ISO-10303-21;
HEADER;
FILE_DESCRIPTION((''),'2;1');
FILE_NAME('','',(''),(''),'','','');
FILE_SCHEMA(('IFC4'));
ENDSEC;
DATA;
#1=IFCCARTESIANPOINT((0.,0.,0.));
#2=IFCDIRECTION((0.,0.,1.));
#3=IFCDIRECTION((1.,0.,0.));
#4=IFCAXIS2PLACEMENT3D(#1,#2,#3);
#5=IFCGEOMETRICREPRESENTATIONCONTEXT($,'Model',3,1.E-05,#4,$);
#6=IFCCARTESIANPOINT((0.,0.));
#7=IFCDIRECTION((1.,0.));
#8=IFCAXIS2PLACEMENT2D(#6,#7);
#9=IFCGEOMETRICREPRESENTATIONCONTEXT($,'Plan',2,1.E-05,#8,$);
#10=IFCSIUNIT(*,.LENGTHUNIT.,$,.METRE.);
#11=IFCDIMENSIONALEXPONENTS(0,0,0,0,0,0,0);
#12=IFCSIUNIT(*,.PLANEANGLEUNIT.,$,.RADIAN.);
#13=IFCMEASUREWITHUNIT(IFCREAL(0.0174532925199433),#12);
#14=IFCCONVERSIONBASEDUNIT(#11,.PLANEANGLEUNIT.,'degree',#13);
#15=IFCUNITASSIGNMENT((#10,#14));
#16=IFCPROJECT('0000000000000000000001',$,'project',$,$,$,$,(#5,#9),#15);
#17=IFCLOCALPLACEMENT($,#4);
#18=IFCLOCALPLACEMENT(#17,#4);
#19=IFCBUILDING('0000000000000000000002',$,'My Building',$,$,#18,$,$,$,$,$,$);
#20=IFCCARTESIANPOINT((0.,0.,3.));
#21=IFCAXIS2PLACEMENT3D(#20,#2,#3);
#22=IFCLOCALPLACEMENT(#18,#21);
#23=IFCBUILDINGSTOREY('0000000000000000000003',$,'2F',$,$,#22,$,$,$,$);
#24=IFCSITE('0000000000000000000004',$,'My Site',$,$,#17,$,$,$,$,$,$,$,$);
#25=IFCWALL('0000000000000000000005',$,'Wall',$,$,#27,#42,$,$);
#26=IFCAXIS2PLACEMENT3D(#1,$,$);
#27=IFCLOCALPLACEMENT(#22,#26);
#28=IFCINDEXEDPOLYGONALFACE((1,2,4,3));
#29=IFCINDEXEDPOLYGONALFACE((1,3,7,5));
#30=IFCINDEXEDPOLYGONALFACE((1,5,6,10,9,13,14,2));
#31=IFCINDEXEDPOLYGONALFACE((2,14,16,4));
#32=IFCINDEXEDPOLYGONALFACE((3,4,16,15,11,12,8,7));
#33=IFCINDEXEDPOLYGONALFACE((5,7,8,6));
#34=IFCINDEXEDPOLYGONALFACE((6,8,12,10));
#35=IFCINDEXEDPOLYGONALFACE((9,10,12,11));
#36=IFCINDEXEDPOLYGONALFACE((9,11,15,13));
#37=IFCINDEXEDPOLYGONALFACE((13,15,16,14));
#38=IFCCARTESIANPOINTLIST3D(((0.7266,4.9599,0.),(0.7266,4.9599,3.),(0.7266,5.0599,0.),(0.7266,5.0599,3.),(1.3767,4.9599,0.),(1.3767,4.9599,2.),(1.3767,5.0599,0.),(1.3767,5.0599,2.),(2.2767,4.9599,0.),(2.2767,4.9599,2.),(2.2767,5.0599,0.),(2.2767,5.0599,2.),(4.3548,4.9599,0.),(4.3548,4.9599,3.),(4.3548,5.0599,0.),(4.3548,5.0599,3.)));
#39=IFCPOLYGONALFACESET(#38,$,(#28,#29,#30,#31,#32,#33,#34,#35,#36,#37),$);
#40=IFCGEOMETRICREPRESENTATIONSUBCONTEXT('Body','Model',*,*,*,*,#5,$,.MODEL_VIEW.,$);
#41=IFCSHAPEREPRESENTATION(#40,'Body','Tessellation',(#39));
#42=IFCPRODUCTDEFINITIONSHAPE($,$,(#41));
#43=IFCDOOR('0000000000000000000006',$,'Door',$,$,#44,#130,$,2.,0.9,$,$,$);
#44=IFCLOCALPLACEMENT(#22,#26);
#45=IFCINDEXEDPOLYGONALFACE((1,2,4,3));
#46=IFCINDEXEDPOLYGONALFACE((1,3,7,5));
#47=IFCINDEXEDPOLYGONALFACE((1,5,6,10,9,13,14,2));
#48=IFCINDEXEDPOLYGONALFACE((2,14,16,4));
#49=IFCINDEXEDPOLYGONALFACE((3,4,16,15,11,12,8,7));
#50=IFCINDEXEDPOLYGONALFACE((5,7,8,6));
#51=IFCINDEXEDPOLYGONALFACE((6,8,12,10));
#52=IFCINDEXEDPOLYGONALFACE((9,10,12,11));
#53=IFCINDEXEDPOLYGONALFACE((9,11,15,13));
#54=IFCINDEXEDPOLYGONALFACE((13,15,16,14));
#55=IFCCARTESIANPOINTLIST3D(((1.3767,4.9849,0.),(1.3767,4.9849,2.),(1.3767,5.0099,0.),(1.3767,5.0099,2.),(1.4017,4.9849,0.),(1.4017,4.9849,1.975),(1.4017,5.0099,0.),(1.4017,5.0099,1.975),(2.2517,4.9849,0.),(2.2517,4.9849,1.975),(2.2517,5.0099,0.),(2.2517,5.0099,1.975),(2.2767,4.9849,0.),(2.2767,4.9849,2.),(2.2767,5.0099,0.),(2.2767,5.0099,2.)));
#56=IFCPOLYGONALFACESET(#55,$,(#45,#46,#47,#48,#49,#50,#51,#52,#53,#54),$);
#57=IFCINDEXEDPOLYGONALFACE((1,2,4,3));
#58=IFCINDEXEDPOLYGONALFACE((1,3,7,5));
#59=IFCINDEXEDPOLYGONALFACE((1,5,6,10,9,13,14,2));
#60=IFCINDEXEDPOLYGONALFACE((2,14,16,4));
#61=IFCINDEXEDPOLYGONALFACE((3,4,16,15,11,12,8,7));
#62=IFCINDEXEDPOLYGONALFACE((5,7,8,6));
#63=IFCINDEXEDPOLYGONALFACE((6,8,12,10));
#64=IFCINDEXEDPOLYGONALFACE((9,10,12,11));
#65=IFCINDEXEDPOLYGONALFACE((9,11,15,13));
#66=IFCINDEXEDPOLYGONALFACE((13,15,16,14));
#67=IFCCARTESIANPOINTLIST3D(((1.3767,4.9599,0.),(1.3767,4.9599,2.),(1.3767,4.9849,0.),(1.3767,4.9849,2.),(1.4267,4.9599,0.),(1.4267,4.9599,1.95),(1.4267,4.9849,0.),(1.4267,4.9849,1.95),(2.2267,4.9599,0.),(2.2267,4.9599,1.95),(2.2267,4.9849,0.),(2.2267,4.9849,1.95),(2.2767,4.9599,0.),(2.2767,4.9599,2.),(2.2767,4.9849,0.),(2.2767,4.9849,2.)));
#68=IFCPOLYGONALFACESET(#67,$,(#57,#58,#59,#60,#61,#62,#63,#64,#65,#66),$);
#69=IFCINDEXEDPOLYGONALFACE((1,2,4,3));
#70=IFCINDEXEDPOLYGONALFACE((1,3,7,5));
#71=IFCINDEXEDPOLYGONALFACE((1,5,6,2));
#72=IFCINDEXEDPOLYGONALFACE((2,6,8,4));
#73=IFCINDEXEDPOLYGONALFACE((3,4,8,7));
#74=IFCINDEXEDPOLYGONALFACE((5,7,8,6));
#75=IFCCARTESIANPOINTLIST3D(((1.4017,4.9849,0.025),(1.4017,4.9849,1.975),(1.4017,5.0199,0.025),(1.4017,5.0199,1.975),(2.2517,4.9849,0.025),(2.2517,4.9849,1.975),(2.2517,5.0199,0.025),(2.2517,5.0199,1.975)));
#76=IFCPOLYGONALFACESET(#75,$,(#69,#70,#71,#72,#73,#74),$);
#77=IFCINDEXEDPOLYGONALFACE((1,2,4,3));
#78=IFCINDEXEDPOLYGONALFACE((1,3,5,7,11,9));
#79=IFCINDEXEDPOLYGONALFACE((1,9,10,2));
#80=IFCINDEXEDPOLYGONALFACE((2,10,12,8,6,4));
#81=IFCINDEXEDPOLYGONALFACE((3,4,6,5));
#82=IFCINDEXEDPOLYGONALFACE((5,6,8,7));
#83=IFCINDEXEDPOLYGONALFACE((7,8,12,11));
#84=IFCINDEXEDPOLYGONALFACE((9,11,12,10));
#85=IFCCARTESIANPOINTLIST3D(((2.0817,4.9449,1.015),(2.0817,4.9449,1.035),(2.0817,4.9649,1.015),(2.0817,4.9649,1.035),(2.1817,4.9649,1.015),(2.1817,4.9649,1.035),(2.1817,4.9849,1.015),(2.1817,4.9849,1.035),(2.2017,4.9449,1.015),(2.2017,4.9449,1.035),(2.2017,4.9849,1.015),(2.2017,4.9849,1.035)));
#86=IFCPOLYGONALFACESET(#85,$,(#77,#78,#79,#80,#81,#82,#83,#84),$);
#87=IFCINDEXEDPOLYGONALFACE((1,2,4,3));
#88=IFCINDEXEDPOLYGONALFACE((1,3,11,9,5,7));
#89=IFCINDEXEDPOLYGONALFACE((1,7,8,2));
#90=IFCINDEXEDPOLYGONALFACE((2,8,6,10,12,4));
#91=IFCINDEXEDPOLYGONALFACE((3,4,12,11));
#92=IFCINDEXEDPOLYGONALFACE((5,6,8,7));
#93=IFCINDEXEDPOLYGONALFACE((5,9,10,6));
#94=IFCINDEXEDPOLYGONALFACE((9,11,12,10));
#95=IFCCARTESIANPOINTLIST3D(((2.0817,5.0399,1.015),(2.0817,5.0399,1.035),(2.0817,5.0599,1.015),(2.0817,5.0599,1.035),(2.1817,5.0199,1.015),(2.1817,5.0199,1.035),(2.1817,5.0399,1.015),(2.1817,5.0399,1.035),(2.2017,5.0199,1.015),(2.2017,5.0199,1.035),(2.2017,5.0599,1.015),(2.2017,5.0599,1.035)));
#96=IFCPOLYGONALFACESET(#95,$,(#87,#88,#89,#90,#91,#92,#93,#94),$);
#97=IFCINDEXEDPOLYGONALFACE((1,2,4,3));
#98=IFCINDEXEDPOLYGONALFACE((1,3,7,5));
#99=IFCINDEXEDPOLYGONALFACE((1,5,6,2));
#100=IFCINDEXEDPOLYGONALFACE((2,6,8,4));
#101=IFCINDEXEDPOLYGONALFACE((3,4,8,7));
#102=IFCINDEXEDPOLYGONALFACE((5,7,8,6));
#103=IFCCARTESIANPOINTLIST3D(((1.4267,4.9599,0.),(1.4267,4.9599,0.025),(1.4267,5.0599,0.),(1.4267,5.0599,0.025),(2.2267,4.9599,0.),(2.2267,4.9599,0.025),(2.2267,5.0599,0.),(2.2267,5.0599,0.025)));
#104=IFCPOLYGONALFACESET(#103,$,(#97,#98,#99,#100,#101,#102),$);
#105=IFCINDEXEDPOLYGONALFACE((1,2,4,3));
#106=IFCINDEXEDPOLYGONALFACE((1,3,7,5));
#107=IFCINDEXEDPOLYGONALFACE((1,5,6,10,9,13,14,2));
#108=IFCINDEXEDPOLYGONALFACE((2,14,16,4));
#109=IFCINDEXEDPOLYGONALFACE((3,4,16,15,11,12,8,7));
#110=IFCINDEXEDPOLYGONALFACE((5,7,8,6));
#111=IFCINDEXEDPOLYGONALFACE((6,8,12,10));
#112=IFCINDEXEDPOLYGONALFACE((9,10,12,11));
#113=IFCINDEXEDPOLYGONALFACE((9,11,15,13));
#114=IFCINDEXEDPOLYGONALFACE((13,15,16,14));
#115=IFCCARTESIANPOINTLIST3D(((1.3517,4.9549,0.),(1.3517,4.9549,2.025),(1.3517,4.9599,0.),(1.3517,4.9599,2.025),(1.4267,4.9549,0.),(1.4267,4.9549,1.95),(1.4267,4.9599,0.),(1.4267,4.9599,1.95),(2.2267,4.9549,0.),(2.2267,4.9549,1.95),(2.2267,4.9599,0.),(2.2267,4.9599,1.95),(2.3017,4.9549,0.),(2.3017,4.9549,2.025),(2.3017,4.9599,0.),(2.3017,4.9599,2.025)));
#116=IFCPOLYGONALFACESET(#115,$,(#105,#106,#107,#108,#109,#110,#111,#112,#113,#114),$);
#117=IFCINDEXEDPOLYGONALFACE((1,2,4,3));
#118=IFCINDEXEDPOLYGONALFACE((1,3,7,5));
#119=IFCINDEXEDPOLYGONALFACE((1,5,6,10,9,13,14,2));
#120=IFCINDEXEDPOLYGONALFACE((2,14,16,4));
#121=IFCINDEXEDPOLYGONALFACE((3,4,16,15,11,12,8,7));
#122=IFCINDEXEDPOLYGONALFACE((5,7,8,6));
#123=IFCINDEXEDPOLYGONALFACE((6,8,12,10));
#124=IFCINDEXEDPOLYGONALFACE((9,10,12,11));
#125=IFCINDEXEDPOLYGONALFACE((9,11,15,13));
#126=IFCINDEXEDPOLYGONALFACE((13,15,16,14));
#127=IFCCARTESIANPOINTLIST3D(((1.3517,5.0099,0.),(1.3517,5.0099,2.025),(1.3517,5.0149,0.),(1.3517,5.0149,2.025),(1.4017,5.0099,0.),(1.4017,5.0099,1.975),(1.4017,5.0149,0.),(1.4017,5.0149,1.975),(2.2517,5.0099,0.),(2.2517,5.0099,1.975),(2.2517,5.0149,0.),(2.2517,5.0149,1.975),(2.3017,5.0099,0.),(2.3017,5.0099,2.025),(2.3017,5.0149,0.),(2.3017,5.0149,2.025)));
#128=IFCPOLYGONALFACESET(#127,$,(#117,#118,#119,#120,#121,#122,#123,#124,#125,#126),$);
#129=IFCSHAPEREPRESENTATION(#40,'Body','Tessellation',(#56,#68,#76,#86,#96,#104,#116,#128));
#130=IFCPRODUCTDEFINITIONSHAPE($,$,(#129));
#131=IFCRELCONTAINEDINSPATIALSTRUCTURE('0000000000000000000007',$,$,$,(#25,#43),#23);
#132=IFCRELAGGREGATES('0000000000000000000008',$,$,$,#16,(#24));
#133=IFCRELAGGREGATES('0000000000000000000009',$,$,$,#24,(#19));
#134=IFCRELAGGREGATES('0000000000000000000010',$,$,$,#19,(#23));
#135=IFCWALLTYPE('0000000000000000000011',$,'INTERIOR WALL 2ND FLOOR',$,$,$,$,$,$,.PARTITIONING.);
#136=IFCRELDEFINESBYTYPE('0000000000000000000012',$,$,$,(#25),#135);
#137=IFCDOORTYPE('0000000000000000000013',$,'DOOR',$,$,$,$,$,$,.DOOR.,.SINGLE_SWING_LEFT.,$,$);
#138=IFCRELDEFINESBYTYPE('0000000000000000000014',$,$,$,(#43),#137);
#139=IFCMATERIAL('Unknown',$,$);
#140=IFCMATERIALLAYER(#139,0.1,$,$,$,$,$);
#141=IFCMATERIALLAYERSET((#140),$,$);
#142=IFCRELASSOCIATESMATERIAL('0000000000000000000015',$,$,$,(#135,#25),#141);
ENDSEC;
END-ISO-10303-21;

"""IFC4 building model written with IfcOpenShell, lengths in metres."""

from ifc_helpers import new_model, entity, si_unit, converted_unit, frame, origin_with_axes, origin_2d_with_axis, place, context, subcontext, project, spatial, line, indexed_curve, outline, extrude, shape, source, transform, mapped, material, layer, layer_set, layer_usage, type_object, type_shapes, element, fill, save


model = new_model("IFC4")

# Units and contexts
model_context = context("Model", 3, precision=1e-05, world=origin_with_axes())
plan_context = context("Plan", 2, precision=1e-05, world=origin_2d_with_axis())
body_context_1 = subcontext(model_context, "Body", "Model", "MODEL_VIEW")
body_context_2 = subcontext(plan_context, "Body", "Plan", "PLAN_VIEW")
ifc_project = project(units=[si_unit("LENGTHUNIT", "METRE"), converted_unit("PLANEANGLEUNIT", "degree", entity("IfcReal", 0.0174532925199433), si_unit("PLANEANGLEUNIT", "RADIAN"), dimensions=[0, 0, 0, 0, 0, 0, 0])], contexts=[model_context, plan_context])

# Site, building, storey
site_placement = place(None, origin_with_axes())
site = spatial("IfcSite", under=ifc_project, at=site_placement, Name="My Site")
building_placement = place(site_placement, origin_with_axes())
building = spatial("IfcBuilding", under=site, at=building_placement, Name="My Building")
storey_placement = place(building_placement, frame((0.0, 0.0, 3.0), z_axis=(0.0, 0.0, 1.0), x_axis=(1.0, 0.0, 0.0)))
storey = spatial("IfcBuildingStorey", under=building, at=storey_placement, Name="2F")

# Shared definitions
ifc_material = material(Name="Unknown")

# Shared definitions
ifc_layer_1 = layer(ifc_material, 0.1)
ifc_layer_set_1 = layer_set([ifc_layer_1])
wall_type_1 = type_object("IfcWallType", Name="INTERIOR WALL 2ND FLOOR", PredefinedType="PARTITIONING", material=ifc_layer_set_1)
shared_shape_1 = source(origin_with_axes(), body_context_1, "Body", "SweptSolid", [
    extrude(outline(indexed_curve([(0.0, 0.0), (0.9, 0.0), (0.9, 2.0), (0.0, 2.0)], segments=[line(1, 2, 3, 4, 1)])), frame((0.0, -0.6, 0.0), z_axis=(0.0, -1.0, 0.0), x_axis=(1.0, 0.0, 0.0)), (0.0, 0.0, -1.0), 1.2),
])
door_type = type_object("IfcDoorType", Name="DOOR", OperationType="SINGLE_SWING_LEFT", PredefinedType="DOOR")
shared_shape_2 = source(origin_with_axes(), body_context_1, "Body", "SweptSolid", [
    extrude(outline(indexed_curve([(0.0, 0.0), (0.0, 2.0), (0.9, 2.0), (0.9, 0.0), (0.875, 0.0), (0.875, 1.975), (0.025, 1.975), (0.025, 0.0)], segments=[line(1, 2, 3, 4, 5, 6, 7, 8, 1)])), frame((0.0, 0.025, 0.0), z_axis=(0.0, -1.0, 0.0), x_axis=(1.0, 0.0, 0.0)), (0.0, 0.0, -1.0), 0.025),
    extrude(outline(indexed_curve([(0.0, 0.0), (0.0, 2.0), (0.9, 2.0), (0.9, 0.0), (0.85, 0.0), (0.85, 1.95), (0.05, 1.95), (0.05, 0.0)], segments=[line(1, 2, 3, 4, 5, 6, 7, 8, 1)])), frame((0.0, 0.0, 0.0), z_axis=(0.0, -1.0, 0.0), x_axis=(1.0, 0.0, 0.0)), (0.0, 0.0, -1.0), 0.025),
    extrude(outline(indexed_curve([(0.0, 0.0), (0.85, 0.0), (0.85, 0.035), (0.0, 0.035)], segments=[line(1, 2, 3, 4, 1)])), frame((0.025, 0.025, 0.025), z_axis=(0.0, 0.0, 1.0), x_axis=(1.0, 0.0, 0.0)), (0.0, 0.0, 1.0), 1.95),
    extrude(outline(indexed_curve([(0.0, 0.0), (0.0, -0.04), (-0.12, -0.04), (-0.12, -0.02), (-0.02, -0.02), (-0.02, 0.0)], segments=[line(1, 2, 3, 4, 5, 6, 1)])), frame((0.825, 0.025, 1.015), z_axis=(0.0, 0.0, 1.0), x_axis=(1.0, 0.0, 0.0)), (0.0, 0.0, 1.0), 0.02),
    extrude(outline(indexed_curve([(0.0, 0.0), (0.0, 0.04), (-0.12, 0.04), (-0.12, 0.02), (-0.02, 0.02), (-0.02, 0.0)], segments=[line(1, 2, 3, 4, 5, 6, 1)])), frame((0.825, 0.06, 1.015), z_axis=(0.0, 0.0, 1.0), x_axis=(1.0, 0.0, 0.0)), (0.0, 0.0, 1.0), 0.02),
    extrude(outline(indexed_curve([(0.0, 0.0), (0.8, 0.0), (0.8, 0.1), (0.0, 0.1)], segments=[line(1, 2, 3, 4, 1)])), frame((0.05, 0.0, 0.0), z_axis=(0.0, 0.0, 1.0), x_axis=(1.0, 0.0, 0.0)), (0.0, 0.0, 1.0), 0.025),
    extrude(outline(indexed_curve([(0.0, 0.0), (0.0, 2.025), (0.95, 2.025), (0.95, 0.0), (0.875, 0.0), (0.875, 1.95), (0.075, 1.95), (0.075, 0.0)], segments=[line(1, 2, 3, 4, 5, 6, 7, 8, 1)])), frame((-0.025, -0.005, 0.0), z_axis=(0.0, -1.0, 0.0), x_axis=(1.0, 0.0, 0.0)), (0.0, 0.0, -1.0), 0.005),
    extrude(outline(indexed_curve([(0.0, 0.0), (0.0, 2.025), (0.95, 2.025), (0.95, 0.0), (0.9, 0.0), (0.9, 1.975), (0.05, 1.975), (0.05, 0.0)], segments=[line(1, 2, 3, 4, 5, 6, 7, 8, 1)])), frame((-0.025, 0.05, 0.0), z_axis=(0.0, -1.0, 0.0), x_axis=(1.0, 0.0, 0.0)), (0.0, 0.0, -1.0), 0.005),
])
shared_shape_3 = source(origin_with_axes(), body_context_2, "Body", "Curve2D", [
    entity("IfcIndexedPolyCurve", entity("IfcCartesianPointList2D", [[0.0, 0.0], [0.0, 0.05], [0.025, 0.05], [0.025, 0.025], [0.05, 0.025], [0.05, 0.0]]), [entity("IfcLineIndex", [1, 2, 3, 4, 5, 6, 1])]),
    entity("IfcIndexedPolyCurve", entity("IfcCartesianPointList2D", [[0.9, 0.0], [0.9, 0.05], [0.875, 0.05], [0.875, 0.025], [0.85, 0.025], [0.85, 0.0]]), [entity("IfcLineIndex", [1, 2, 3, 4, 5, 6, 1])]),
    entity("IfcTrimmedCurve", entity("IfcEllipse", entity("IfcAxis2Placement2D", entity("IfcCartesianPoint", [0.06, 0.05]), entity("IfcDirection", [1.0, 0.0])), 0.815, 0.85), [entity("IfcCartesianPoint", [0.875, 0.05])], [entity("IfcCartesianPoint", [0.06, 0.9])], True, "CARTESIAN"),
    entity("IfcIndexedPolyCurve", entity("IfcCartesianPointList2D", [[0.025, 0.05], [0.06, 0.05], [0.06, 0.9], [0.025, 0.9]]), [entity("IfcLineIndex", [1, 2, 3, 4, 1])]),
])
type_shapes(door_type, [shared_shape_2, shared_shape_3])

# Wall, opening, door
ifc_layer_usage_1 = layer_usage(ifc_layer_set_1, "AXIS2", "POSITIVE", 0.0)
wall_1_placement = place(storey_placement, frame((0.7266, 4.9599, 0.0), z_axis=(0.0, 0.0, 1.0), x_axis=(1.0, 0.0, 0.0)))
wall_1 = element("IfcWall", 1, at=wall_1_placement, inside=storey, type_object=wall_type_1, material=ifc_layer_usage_1, Name="Wall", context=body_context_1, shape_type="SweptSolid", body=[
    extrude(outline(indexed_curve([(0.0, 0.0), (0.0, 0.1), (3.6282, 0.1), (3.6282, 0.0)], segments=[line(1, 2, 3, 4, 1)])), origin_with_axes(), (0.0, 0.0, 1.0), 3.0),
])
opening_1_placement = place(wall_1_placement, frame((0.6501, 0.0, 0.0), z_axis=(0.0, 0.0, 1.0), x_axis=(1.0, 0.0, 0.0)))
opening_1 = element("IfcOpeningElement", 2, at=opening_1_placement, cuts=wall_1, PredefinedType="OPENING", context=body_context_1, shape_type="MappedRepresentation", body=[
    mapped(shared_shape_1, transform((0.0, 0.0, 0.0), x_axis=(1.0, 0.0, 0.0), y_axis=(0.0, 1.0, 0.0), z_axis=(0.0, 0.0, 1.0), scale=1.0)),
])
door_1_placement = place(opening_1_placement, origin_with_axes())
door_1 = element("IfcDoor", 3, at=door_1_placement, inside=storey, type_object=door_type, Name="Door", OverallHeight=2.0, OverallWidth=0.9, shapes=[
    shape(body_context_1, "Body", "MappedRepresentation", [mapped(shared_shape_2, transform((0.0, 0.0, 0.0), x_axis=(1.0, 0.0, 0.0), y_axis=(0.0, 1.0, 0.0), z_axis=(0.0, 0.0, 1.0), scale=1.0))]),
    shape(body_context_2, "Body", "MappedRepresentation", [mapped(shared_shape_3, transform((0.0, 0.0, 0.0), x_axis=(1.0, 0.0, 0.0), y_axis=(0.0, 1.0, 0.0), z_axis=(0.0, 0.0, 1.0), scale=1.0))]),
])
fill(opening_1, door_1)

save(model, "model.ifc")
